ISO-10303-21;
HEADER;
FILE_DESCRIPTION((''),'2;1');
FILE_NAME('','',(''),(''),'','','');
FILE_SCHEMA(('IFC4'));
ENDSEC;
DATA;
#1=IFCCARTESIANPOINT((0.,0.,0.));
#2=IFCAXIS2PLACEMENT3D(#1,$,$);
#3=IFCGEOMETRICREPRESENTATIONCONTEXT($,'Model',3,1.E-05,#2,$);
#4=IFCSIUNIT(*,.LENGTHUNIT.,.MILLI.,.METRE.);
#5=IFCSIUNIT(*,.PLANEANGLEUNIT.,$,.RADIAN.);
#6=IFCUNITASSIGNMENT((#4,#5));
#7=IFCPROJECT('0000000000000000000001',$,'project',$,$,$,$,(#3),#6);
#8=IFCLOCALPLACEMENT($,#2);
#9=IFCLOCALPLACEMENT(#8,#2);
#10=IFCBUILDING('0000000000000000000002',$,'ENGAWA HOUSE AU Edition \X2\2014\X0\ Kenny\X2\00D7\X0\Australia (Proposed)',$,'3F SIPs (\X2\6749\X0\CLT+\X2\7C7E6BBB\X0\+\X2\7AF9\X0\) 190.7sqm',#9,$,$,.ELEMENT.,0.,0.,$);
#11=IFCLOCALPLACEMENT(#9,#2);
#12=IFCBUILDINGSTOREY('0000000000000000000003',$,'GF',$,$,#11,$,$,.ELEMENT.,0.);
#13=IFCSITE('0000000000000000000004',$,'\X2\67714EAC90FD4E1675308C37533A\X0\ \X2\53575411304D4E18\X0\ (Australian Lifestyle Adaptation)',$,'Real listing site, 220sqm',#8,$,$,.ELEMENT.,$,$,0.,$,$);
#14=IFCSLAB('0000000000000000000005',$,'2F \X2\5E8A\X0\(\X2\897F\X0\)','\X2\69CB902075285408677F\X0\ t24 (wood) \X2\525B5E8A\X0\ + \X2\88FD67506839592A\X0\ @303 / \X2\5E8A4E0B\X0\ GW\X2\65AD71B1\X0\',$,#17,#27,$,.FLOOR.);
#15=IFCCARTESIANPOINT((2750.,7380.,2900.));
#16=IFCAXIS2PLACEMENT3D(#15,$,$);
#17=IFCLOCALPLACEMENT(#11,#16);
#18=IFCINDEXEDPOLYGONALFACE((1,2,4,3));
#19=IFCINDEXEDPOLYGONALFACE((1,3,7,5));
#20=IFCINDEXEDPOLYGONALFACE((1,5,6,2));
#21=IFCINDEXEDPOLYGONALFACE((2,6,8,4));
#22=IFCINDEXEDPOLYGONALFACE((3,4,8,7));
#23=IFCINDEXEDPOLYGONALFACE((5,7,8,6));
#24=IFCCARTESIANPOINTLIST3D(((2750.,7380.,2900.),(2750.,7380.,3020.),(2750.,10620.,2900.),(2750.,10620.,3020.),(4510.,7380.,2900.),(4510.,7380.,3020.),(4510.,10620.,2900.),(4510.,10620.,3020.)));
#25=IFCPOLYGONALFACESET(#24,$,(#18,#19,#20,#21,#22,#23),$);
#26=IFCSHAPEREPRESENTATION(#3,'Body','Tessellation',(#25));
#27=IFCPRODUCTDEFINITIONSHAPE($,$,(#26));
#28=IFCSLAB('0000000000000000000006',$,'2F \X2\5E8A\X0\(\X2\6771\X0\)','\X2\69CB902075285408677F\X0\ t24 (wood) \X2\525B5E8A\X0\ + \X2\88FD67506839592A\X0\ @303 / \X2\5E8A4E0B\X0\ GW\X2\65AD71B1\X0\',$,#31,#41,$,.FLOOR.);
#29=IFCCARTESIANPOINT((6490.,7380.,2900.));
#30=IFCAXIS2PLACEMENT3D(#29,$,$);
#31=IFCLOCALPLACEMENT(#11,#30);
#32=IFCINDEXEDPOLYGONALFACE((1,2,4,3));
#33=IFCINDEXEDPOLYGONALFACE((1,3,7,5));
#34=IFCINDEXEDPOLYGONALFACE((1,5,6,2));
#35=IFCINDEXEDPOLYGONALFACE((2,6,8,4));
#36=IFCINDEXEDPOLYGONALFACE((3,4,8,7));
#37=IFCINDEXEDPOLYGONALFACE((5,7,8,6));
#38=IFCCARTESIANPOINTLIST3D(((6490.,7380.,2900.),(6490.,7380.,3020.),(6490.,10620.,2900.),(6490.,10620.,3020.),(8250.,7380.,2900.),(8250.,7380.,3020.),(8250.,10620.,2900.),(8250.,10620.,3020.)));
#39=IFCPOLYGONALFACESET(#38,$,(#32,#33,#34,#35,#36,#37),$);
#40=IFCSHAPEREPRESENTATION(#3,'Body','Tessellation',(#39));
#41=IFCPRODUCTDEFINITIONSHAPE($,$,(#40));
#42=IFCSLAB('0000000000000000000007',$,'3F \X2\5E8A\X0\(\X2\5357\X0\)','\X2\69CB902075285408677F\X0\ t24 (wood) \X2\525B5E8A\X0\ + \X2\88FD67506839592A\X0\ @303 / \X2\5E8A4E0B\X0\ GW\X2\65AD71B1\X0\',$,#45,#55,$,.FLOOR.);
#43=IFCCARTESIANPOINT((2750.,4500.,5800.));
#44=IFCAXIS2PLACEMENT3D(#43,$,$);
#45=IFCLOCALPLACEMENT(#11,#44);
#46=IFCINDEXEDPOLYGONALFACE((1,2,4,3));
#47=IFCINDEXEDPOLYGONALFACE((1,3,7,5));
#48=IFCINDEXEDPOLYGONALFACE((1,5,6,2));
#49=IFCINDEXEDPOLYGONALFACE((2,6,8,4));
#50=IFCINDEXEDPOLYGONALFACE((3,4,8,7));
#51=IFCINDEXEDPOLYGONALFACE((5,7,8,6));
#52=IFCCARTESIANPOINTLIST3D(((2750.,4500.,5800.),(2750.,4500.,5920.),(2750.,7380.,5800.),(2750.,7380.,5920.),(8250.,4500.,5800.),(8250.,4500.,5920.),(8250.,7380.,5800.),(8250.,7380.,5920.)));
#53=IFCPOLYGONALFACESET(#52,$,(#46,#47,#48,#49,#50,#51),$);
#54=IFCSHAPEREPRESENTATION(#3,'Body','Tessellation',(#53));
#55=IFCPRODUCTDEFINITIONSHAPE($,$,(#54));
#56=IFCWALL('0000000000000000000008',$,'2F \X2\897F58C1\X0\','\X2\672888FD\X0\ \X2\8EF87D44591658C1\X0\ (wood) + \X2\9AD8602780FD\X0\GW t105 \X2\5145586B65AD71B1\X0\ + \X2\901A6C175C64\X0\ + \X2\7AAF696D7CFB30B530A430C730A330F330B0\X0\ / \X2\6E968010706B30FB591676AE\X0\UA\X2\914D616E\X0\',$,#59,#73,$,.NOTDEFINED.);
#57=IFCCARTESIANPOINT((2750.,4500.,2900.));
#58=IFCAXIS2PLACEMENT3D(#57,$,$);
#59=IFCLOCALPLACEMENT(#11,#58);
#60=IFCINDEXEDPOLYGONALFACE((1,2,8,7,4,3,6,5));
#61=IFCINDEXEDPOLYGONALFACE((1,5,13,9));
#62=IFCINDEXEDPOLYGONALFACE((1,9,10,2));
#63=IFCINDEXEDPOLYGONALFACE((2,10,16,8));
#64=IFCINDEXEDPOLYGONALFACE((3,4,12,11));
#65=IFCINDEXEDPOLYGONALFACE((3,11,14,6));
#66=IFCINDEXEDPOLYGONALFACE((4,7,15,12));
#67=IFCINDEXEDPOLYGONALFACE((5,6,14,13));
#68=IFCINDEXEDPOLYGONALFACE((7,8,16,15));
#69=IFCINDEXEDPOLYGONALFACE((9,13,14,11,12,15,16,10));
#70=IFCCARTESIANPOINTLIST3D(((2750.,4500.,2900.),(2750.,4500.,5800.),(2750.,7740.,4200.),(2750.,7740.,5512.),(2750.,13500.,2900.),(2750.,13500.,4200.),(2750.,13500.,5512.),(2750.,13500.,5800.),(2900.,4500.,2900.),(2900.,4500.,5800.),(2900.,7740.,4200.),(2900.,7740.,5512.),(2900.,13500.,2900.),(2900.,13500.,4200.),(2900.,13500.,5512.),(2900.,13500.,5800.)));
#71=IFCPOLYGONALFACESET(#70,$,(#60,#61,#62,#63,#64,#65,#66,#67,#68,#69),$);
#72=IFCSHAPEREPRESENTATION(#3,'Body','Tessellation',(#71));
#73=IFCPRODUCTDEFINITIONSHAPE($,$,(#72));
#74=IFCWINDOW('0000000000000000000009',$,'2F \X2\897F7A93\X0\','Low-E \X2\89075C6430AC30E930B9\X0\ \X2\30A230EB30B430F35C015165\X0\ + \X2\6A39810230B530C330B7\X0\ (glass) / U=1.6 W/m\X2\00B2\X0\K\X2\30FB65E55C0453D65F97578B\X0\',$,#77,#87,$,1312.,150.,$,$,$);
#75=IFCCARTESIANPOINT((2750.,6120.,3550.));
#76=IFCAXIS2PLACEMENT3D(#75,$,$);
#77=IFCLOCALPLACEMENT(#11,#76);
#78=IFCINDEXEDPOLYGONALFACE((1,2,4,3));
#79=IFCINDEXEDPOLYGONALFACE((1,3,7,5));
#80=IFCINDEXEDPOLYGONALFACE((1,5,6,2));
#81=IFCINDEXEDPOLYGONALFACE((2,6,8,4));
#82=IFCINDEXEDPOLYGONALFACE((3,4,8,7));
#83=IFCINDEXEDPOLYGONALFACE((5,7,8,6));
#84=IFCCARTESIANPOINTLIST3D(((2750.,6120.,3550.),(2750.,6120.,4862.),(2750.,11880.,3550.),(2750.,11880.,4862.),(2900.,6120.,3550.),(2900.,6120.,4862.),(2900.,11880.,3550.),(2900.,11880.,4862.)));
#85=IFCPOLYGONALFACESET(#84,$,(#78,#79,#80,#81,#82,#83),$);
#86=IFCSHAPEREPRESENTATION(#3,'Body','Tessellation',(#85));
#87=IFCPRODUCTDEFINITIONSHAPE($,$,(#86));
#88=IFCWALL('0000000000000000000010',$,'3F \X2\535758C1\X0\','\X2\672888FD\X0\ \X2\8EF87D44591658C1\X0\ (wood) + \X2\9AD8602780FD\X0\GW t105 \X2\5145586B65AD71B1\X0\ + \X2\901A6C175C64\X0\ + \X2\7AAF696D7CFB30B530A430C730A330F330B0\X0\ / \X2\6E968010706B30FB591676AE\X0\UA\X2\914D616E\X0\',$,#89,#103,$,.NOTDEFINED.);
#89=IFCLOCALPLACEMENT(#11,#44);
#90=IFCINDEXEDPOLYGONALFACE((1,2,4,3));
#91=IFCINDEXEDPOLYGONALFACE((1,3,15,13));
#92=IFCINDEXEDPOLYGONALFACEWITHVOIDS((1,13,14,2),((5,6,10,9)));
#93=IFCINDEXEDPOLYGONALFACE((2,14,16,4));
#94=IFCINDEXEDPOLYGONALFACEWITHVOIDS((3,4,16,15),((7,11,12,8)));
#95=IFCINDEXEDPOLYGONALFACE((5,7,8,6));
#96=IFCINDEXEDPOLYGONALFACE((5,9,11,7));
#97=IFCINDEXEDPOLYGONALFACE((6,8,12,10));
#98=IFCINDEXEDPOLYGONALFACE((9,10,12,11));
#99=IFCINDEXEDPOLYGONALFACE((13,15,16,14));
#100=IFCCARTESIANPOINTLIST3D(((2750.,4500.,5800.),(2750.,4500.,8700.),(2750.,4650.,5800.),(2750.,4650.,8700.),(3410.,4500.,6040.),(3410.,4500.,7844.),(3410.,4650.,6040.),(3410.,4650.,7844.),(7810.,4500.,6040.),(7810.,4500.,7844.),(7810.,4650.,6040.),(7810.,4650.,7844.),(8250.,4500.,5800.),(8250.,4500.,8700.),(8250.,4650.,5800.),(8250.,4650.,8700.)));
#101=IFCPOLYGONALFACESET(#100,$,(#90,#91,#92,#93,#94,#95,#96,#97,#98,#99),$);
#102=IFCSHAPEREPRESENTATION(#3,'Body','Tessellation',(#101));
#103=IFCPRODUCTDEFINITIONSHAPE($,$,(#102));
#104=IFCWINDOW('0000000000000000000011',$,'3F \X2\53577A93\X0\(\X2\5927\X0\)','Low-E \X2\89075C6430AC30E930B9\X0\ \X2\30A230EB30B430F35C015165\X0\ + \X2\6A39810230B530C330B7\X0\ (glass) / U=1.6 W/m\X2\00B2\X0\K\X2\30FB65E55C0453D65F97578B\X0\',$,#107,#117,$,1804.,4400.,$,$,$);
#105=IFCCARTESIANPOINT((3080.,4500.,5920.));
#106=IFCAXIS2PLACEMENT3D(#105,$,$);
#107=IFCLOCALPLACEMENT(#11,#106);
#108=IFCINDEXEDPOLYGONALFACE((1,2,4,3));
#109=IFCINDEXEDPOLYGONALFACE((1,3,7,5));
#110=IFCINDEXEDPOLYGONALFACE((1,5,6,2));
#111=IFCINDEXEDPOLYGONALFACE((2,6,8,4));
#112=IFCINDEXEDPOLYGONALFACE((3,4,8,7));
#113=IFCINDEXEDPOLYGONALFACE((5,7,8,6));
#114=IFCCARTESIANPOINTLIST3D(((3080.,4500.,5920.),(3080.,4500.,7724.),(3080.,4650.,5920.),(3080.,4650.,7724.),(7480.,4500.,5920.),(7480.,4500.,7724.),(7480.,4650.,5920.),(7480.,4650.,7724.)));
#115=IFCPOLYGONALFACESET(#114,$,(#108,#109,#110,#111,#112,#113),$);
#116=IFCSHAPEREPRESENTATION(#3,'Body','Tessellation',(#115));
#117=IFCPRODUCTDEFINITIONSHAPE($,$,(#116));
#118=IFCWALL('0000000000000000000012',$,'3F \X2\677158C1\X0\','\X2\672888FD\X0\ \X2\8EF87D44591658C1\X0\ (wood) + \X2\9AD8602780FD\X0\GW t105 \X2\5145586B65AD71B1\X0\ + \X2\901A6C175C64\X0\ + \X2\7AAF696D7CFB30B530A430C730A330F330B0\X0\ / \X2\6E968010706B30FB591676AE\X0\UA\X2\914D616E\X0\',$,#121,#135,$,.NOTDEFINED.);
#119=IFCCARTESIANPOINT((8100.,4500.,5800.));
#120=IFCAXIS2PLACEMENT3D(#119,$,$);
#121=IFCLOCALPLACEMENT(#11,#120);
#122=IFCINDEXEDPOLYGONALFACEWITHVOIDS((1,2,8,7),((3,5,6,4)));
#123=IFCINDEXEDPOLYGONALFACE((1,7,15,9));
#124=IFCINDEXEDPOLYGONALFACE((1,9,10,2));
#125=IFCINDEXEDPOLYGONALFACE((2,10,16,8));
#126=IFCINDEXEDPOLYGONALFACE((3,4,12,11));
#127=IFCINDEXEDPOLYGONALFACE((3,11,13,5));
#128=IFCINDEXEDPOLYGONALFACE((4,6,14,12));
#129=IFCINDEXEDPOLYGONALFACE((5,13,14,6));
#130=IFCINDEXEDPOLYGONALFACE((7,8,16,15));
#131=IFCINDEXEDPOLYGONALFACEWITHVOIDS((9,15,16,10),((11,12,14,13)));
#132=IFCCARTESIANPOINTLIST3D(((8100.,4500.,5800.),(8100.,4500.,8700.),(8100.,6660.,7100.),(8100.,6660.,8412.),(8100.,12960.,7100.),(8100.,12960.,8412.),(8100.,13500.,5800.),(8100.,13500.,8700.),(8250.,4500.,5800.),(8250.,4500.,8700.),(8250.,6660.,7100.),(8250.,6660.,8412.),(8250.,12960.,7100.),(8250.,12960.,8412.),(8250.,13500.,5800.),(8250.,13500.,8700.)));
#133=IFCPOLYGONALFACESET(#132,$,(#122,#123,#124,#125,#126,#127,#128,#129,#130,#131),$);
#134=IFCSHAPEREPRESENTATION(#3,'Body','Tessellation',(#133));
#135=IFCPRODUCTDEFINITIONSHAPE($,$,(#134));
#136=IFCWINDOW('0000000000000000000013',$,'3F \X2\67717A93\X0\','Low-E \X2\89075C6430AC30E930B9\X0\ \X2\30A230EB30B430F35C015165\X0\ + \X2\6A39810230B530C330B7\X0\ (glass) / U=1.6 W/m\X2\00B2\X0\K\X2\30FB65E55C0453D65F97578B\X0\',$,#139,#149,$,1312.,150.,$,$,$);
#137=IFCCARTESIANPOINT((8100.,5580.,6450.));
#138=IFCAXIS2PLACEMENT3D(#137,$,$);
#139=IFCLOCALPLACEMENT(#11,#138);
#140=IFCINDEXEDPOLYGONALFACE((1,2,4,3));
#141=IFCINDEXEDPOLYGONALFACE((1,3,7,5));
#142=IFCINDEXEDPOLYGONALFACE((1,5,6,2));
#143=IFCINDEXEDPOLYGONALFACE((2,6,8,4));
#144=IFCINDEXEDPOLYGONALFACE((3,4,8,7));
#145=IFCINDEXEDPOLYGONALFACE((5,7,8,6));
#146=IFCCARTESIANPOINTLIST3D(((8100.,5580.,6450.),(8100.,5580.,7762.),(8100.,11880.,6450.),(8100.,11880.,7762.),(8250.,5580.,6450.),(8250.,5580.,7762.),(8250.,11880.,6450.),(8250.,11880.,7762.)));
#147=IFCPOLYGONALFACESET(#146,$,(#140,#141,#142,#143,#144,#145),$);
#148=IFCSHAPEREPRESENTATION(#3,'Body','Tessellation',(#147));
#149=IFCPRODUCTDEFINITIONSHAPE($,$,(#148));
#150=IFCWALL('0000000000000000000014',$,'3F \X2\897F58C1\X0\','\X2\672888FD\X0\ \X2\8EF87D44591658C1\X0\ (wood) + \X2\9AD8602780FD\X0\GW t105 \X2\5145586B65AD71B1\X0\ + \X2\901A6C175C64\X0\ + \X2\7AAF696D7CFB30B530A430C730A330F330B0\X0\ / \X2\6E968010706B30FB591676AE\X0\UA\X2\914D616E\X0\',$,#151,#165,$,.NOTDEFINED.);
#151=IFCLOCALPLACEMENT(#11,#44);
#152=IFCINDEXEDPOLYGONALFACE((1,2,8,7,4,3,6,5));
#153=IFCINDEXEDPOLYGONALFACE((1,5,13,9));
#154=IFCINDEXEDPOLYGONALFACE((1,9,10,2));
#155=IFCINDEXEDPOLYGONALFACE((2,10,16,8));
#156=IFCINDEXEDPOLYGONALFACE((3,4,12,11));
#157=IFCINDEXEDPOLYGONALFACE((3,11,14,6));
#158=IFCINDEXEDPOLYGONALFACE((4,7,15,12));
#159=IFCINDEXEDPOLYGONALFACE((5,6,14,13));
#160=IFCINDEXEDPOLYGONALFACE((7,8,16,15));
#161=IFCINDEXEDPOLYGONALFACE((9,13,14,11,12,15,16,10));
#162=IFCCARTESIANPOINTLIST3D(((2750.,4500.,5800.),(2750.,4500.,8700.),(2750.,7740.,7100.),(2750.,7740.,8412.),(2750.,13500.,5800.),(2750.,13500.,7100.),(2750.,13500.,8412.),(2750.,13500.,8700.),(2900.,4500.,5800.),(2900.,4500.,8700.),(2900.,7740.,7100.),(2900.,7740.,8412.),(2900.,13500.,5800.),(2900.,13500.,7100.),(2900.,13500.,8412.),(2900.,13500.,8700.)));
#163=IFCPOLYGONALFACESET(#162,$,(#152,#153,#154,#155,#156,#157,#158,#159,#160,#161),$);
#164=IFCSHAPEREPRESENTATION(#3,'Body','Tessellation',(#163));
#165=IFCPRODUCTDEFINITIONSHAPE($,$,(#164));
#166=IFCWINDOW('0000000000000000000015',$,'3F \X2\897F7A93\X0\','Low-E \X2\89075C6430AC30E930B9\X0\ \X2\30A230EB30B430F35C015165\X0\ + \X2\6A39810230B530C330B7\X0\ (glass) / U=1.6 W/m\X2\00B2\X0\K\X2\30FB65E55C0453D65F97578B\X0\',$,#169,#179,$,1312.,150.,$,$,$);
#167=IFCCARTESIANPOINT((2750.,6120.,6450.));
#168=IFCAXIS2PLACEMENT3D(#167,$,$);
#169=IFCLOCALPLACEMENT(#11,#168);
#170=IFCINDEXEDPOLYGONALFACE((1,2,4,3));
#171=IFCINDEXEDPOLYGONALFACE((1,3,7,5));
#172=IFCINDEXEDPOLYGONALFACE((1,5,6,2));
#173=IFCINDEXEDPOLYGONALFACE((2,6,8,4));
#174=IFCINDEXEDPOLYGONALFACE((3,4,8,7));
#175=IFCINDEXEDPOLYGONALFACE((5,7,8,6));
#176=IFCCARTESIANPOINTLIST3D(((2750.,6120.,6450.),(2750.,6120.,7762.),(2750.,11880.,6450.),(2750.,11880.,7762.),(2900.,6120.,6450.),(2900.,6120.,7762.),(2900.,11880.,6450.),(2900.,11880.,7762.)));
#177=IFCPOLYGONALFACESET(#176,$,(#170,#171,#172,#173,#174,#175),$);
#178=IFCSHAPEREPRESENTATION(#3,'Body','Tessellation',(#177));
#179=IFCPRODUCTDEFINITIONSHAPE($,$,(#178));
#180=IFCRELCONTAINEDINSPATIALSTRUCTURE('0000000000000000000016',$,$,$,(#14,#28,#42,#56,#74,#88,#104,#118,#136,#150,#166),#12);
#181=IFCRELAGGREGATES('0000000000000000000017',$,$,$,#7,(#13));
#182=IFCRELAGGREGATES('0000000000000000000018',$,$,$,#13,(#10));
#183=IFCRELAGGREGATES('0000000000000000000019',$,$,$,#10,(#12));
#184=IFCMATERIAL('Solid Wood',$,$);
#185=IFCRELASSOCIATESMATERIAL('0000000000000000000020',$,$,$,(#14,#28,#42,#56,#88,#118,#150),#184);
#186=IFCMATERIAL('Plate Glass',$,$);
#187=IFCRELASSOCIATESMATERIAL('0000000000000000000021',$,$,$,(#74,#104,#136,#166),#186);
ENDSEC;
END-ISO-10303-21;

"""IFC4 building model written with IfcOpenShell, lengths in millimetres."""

from ifc_helpers import new_model, si_unit, frame, frame_2d, origin, place, context, project, spatial, rectangle, extrude, material, element, fill, save


model = new_model("IFC4")

# Units and contexts
model_context = context("Model", 3, precision=1e-05, world=origin())
ifc_project = project(units=[si_unit("LENGTHUNIT", "METRE", prefix="MILLI"), si_unit("PLANEANGLEUNIT", "RADIAN")], contexts=[model_context])

# Site, building, storey
site_placement = place(None, origin())
site = spatial("IfcSite", under=ifc_project, at=site_placement, Name="東京都世田谷区 南向き丘 (Australian Lifestyle Adaptation)", ObjectType="Real listing site, 220sqm", CompositionType="ELEMENT", RefElevation=0.0)
building_placement = place(site_placement, origin())
building = spatial("IfcBuilding", under=site, at=building_placement, Name="ENGAWA HOUSE AU Edition — Kenny×Australia (Proposed)", ObjectType="3F SIPs (杉CLT+籾殻+竹) 190.7sqm", CompositionType="ELEMENT", ElevationOfRefHeight=0.0, ElevationOfTerrain=0.0)
storey_placement = place(building_placement, origin())
storey = spatial("IfcBuildingStorey", under=building, at=storey_placement, Name="GF", CompositionType="ELEMENT", Elevation=0.0)

# Slabs
ifc_material_1 = material(Name="Solid Wood")
slab_1_placement = place(storey_placement, frame((2750.0, 7380.0, 2900.0)))
element("IfcSlab", 1, at=slab_1_placement, inside=storey, material=ifc_material_1, Name="2F 床(西)", Description="構造用合板 t24 (wood) 剛床 + 製材根太 @303 / 床下 GW断熱", PredefinedType="FLOOR", context=model_context, shape_type="SweptSolid", body=[
    extrude(rectangle(XDim=1760.0, YDim=3240.0, at=frame_2d((880.0, 1620.0))), frame((2750.0, 7380.0, 2900.0)), (0.0, 0.0, 1.0), 120.0),
])
slab_2_placement = place(storey_placement, frame((6490.0, 7380.0, 2900.0)))
element("IfcSlab", 2, at=slab_2_placement, inside=storey, material=ifc_material_1, Name="2F 床(東)", Description="構造用合板 t24 (wood) 剛床 + 製材根太 @303 / 床下 GW断熱", PredefinedType="FLOOR", context=model_context, shape_type="SweptSolid", body=[
    extrude(rectangle(XDim=1760.0, YDim=3240.0, at=frame_2d((880.0, 1620.0))), frame((6490.0, 7380.0, 2900.0)), (0.0, 0.0, 1.0), 120.0),
])
slab_3_placement = place(storey_placement, frame((2750.0, 4500.0, 5800.0)))
element("IfcSlab", 3, at=slab_3_placement, inside=storey, material=ifc_material_1, Name="3F 床(南)", Description="構造用合板 t24 (wood) 剛床 + 製材根太 @303 / 床下 GW断熱", PredefinedType="FLOOR", context=model_context, shape_type="SweptSolid", body=[
    extrude(rectangle(XDim=5500.0, YDim=2880.0, at=frame_2d((2750.0, 1440.0))), frame((2750.0, 4500.0, 5800.0)), (0.0, 0.0, 1.0), 120.0),
])

# Walls, openings, windows
wall_1_placement = place(storey_placement, frame((2750.0, 4500.0, 2900.0)))
wall_1 = element("IfcWall", 4, at=wall_1_placement, inside=storey, material=ifc_material_1, Name="2F 西壁", Description="木製 軸組外壁 (wood) + 高性能GW t105 充填断熱 + 通気層 + 窯業系サイディング / 準耐火・外皮UA配慮", PredefinedType="NOTDEFINED", context=model_context, shape_type="SweptSolid", body=[
    extrude(rectangle(XDim=150.0, YDim=9000.0, at=frame_2d((75.0, 4500.0))), frame((2750.0, 4500.0, 2900.0)), (0.0, 0.0, 1.0), 2900.0),
])
opening_1_placement = place(storey_placement, frame((2750.0, 6120.0, 3550.0)))
opening_1 = element("IfcOpeningElement", 5, at=opening_1_placement, cuts=wall_1, PredefinedType="NOTDEFINED", context=model_context, shape_type="SweptSolid", body=[
    extrude(rectangle(XDim=150.0, YDim=5760.0, at=frame_2d((75.0, 2880.0))), frame((2750.0, 6120.0, 3550.0)), (0.0, 0.0, 1.0), 1312.0),
])
ifc_material_2 = material(Name="Plate Glass")
window_1_placement = place(storey_placement, frame((2750.0, 6120.0, 3550.0)))
window_1 = element("IfcWindow", 6, at=window_1_placement, inside=storey, material=ifc_material_2, Name="2F 西窓", Description="Low-E 複層ガラス アルゴン封入 + 樹脂サッシ (glass) / U=1.6 W/m²K・日射取得型", OverallHeight=1312.0, OverallWidth=150.0, context=model_context, shape_type="SweptSolid", body=[
    extrude(rectangle(XDim=150.0, YDim=5760.0, at=frame_2d((75.0, 2880.0))), frame((2750.0, 6120.0, 3550.0)), (0.0, 0.0, 1.0), 1312.0),
])
fill(opening_1, window_1)
wall_2_placement = place(storey_placement, frame((2750.0, 4500.0, 5800.0)))
wall_2 = element("IfcWall", 7, at=wall_2_placement, inside=storey, material=ifc_material_1, Name="3F 南壁", Description="木製 軸組外壁 (wood) + 高性能GW t105 充填断熱 + 通気層 + 窯業系サイディング / 準耐火・外皮UA配慮", PredefinedType="NOTDEFINED", context=model_context, shape_type="SweptSolid", body=[
    extrude(rectangle(XDim=5500.0, YDim=150.0, at=frame_2d((2750.0, 75.0))), frame((2750.0, 4500.0, 5800.0)), (0.0, 0.0, 1.0), 2900.0),
])
opening_2_placement = place(storey_placement, frame((3080.0, 4500.0, 5920.0)))
opening_2 = element("IfcOpeningElement", 8, at=opening_2_placement, cuts=wall_2, PredefinedType="NOTDEFINED", context=model_context, shape_type="SweptSolid", body=[
    extrude(rectangle(XDim=4400.0, YDim=150.0, at=frame_2d((2200.0, 75.0))), frame((3080.0, 4500.0, 5920.0)), (0.0, 0.0, 1.0), 1804.0),
])
window_2_placement = place(storey_placement, frame((3080.0, 4500.0, 5920.0)))
window_2 = element("IfcWindow", 9, at=window_2_placement, inside=storey, material=ifc_material_2, Name="3F 南窓(大)", Description="Low-E 複層ガラス アルゴン封入 + 樹脂サッシ (glass) / U=1.6 W/m²K・日射取得型", OverallHeight=1804.0, OverallWidth=4400.0, context=model_context, shape_type="SweptSolid", body=[
    extrude(rectangle(XDim=4400.0, YDim=150.0, at=frame_2d((2200.0, 75.0))), frame((3080.0, 4500.0, 5920.0)), (0.0, 0.0, 1.0), 1804.0),
])
fill(opening_2, window_2)
wall_3_placement = place(storey_placement, frame((8100.0, 4500.0, 5800.0)))
wall_3 = element("IfcWall", 10, at=wall_3_placement, inside=storey, material=ifc_material_1, Name="3F 東壁", Description="木製 軸組外壁 (wood) + 高性能GW t105 充填断熱 + 通気層 + 窯業系サイディング / 準耐火・外皮UA配慮", PredefinedType="NOTDEFINED", context=model_context, shape_type="SweptSolid", body=[
    extrude(rectangle(XDim=150.0, YDim=9000.0, at=frame_2d((75.0, 4500.0))), frame((8100.0, 4500.0, 5800.0)), (0.0, 0.0, 1.0), 2900.0),
])
opening_3_placement = place(storey_placement, frame((8100.0, 5580.0, 6450.0)))
opening_3 = element("IfcOpeningElement", 11, at=opening_3_placement, cuts=wall_3, PredefinedType="NOTDEFINED", context=model_context, shape_type="SweptSolid", body=[
    extrude(rectangle(XDim=150.0, YDim=6300.0, at=frame_2d((75.0, 3150.0))), frame((8100.0, 5580.0, 6450.0)), (0.0, 0.0, 1.0), 1312.0),
])
window_3_placement = place(storey_placement, frame((8100.0, 5580.0, 6450.0)))
window_3 = element("IfcWindow", 12, at=window_3_placement, inside=storey, material=ifc_material_2, Name="3F 東窓", Description="Low-E 複層ガラス アルゴン封入 + 樹脂サッシ (glass) / U=1.6 W/m²K・日射取得型", OverallHeight=1312.0, OverallWidth=150.0, context=model_context, shape_type="SweptSolid", body=[
    extrude(rectangle(XDim=150.0, YDim=6300.0, at=frame_2d((75.0, 3150.0))), frame((8100.0, 5580.0, 6450.0)), (0.0, 0.0, 1.0), 1312.0),
])
fill(opening_3, window_3)
wall_4_placement = place(storey_placement, frame((2750.0, 4500.0, 5800.0)))
wall_4 = element("IfcWall", 13, at=wall_4_placement, inside=storey, material=ifc_material_1, Name="3F 西壁", Description="木製 軸組外壁 (wood) + 高性能GW t105 充填断熱 + 通気層 + 窯業系サイディング / 準耐火・外皮UA配慮", PredefinedType="NOTDEFINED", context=model_context, shape_type="SweptSolid", body=[
    extrude(rectangle(XDim=150.0, YDim=9000.0, at=frame_2d((75.0, 4500.0))), frame((2750.0, 4500.0, 5800.0)), (0.0, 0.0, 1.0), 2900.0),
])
opening_4_placement = place(storey_placement, frame((2750.0, 6120.0, 6450.0)))
opening_4 = element("IfcOpeningElement", 14, at=opening_4_placement, cuts=wall_4, PredefinedType="NOTDEFINED", context=model_context, shape_type="SweptSolid", body=[
    extrude(rectangle(XDim=150.0, YDim=5760.0, at=frame_2d((75.0, 2880.0))), frame((2750.0, 6120.0, 6450.0)), (0.0, 0.0, 1.0), 1312.0),
])
window_4_placement = place(storey_placement, frame((2750.0, 6120.0, 6450.0)))
window_4 = element("IfcWindow", 15, at=window_4_placement, inside=storey, material=ifc_material_2, Name="3F 西窓", Description="Low-E 複層ガラス アルゴン封入 + 樹脂サッシ (glass) / U=1.6 W/m²K・日射取得型", OverallHeight=1312.0, OverallWidth=150.0, context=model_context, shape_type="SweptSolid", body=[
    extrude(rectangle(XDim=150.0, YDim=5760.0, at=frame_2d((75.0, 2880.0))), frame((2750.0, 6120.0, 6450.0)), (0.0, 0.0, 1.0), 1312.0),
])
fill(opening_4, window_4)

save(model, "model.ifc")
